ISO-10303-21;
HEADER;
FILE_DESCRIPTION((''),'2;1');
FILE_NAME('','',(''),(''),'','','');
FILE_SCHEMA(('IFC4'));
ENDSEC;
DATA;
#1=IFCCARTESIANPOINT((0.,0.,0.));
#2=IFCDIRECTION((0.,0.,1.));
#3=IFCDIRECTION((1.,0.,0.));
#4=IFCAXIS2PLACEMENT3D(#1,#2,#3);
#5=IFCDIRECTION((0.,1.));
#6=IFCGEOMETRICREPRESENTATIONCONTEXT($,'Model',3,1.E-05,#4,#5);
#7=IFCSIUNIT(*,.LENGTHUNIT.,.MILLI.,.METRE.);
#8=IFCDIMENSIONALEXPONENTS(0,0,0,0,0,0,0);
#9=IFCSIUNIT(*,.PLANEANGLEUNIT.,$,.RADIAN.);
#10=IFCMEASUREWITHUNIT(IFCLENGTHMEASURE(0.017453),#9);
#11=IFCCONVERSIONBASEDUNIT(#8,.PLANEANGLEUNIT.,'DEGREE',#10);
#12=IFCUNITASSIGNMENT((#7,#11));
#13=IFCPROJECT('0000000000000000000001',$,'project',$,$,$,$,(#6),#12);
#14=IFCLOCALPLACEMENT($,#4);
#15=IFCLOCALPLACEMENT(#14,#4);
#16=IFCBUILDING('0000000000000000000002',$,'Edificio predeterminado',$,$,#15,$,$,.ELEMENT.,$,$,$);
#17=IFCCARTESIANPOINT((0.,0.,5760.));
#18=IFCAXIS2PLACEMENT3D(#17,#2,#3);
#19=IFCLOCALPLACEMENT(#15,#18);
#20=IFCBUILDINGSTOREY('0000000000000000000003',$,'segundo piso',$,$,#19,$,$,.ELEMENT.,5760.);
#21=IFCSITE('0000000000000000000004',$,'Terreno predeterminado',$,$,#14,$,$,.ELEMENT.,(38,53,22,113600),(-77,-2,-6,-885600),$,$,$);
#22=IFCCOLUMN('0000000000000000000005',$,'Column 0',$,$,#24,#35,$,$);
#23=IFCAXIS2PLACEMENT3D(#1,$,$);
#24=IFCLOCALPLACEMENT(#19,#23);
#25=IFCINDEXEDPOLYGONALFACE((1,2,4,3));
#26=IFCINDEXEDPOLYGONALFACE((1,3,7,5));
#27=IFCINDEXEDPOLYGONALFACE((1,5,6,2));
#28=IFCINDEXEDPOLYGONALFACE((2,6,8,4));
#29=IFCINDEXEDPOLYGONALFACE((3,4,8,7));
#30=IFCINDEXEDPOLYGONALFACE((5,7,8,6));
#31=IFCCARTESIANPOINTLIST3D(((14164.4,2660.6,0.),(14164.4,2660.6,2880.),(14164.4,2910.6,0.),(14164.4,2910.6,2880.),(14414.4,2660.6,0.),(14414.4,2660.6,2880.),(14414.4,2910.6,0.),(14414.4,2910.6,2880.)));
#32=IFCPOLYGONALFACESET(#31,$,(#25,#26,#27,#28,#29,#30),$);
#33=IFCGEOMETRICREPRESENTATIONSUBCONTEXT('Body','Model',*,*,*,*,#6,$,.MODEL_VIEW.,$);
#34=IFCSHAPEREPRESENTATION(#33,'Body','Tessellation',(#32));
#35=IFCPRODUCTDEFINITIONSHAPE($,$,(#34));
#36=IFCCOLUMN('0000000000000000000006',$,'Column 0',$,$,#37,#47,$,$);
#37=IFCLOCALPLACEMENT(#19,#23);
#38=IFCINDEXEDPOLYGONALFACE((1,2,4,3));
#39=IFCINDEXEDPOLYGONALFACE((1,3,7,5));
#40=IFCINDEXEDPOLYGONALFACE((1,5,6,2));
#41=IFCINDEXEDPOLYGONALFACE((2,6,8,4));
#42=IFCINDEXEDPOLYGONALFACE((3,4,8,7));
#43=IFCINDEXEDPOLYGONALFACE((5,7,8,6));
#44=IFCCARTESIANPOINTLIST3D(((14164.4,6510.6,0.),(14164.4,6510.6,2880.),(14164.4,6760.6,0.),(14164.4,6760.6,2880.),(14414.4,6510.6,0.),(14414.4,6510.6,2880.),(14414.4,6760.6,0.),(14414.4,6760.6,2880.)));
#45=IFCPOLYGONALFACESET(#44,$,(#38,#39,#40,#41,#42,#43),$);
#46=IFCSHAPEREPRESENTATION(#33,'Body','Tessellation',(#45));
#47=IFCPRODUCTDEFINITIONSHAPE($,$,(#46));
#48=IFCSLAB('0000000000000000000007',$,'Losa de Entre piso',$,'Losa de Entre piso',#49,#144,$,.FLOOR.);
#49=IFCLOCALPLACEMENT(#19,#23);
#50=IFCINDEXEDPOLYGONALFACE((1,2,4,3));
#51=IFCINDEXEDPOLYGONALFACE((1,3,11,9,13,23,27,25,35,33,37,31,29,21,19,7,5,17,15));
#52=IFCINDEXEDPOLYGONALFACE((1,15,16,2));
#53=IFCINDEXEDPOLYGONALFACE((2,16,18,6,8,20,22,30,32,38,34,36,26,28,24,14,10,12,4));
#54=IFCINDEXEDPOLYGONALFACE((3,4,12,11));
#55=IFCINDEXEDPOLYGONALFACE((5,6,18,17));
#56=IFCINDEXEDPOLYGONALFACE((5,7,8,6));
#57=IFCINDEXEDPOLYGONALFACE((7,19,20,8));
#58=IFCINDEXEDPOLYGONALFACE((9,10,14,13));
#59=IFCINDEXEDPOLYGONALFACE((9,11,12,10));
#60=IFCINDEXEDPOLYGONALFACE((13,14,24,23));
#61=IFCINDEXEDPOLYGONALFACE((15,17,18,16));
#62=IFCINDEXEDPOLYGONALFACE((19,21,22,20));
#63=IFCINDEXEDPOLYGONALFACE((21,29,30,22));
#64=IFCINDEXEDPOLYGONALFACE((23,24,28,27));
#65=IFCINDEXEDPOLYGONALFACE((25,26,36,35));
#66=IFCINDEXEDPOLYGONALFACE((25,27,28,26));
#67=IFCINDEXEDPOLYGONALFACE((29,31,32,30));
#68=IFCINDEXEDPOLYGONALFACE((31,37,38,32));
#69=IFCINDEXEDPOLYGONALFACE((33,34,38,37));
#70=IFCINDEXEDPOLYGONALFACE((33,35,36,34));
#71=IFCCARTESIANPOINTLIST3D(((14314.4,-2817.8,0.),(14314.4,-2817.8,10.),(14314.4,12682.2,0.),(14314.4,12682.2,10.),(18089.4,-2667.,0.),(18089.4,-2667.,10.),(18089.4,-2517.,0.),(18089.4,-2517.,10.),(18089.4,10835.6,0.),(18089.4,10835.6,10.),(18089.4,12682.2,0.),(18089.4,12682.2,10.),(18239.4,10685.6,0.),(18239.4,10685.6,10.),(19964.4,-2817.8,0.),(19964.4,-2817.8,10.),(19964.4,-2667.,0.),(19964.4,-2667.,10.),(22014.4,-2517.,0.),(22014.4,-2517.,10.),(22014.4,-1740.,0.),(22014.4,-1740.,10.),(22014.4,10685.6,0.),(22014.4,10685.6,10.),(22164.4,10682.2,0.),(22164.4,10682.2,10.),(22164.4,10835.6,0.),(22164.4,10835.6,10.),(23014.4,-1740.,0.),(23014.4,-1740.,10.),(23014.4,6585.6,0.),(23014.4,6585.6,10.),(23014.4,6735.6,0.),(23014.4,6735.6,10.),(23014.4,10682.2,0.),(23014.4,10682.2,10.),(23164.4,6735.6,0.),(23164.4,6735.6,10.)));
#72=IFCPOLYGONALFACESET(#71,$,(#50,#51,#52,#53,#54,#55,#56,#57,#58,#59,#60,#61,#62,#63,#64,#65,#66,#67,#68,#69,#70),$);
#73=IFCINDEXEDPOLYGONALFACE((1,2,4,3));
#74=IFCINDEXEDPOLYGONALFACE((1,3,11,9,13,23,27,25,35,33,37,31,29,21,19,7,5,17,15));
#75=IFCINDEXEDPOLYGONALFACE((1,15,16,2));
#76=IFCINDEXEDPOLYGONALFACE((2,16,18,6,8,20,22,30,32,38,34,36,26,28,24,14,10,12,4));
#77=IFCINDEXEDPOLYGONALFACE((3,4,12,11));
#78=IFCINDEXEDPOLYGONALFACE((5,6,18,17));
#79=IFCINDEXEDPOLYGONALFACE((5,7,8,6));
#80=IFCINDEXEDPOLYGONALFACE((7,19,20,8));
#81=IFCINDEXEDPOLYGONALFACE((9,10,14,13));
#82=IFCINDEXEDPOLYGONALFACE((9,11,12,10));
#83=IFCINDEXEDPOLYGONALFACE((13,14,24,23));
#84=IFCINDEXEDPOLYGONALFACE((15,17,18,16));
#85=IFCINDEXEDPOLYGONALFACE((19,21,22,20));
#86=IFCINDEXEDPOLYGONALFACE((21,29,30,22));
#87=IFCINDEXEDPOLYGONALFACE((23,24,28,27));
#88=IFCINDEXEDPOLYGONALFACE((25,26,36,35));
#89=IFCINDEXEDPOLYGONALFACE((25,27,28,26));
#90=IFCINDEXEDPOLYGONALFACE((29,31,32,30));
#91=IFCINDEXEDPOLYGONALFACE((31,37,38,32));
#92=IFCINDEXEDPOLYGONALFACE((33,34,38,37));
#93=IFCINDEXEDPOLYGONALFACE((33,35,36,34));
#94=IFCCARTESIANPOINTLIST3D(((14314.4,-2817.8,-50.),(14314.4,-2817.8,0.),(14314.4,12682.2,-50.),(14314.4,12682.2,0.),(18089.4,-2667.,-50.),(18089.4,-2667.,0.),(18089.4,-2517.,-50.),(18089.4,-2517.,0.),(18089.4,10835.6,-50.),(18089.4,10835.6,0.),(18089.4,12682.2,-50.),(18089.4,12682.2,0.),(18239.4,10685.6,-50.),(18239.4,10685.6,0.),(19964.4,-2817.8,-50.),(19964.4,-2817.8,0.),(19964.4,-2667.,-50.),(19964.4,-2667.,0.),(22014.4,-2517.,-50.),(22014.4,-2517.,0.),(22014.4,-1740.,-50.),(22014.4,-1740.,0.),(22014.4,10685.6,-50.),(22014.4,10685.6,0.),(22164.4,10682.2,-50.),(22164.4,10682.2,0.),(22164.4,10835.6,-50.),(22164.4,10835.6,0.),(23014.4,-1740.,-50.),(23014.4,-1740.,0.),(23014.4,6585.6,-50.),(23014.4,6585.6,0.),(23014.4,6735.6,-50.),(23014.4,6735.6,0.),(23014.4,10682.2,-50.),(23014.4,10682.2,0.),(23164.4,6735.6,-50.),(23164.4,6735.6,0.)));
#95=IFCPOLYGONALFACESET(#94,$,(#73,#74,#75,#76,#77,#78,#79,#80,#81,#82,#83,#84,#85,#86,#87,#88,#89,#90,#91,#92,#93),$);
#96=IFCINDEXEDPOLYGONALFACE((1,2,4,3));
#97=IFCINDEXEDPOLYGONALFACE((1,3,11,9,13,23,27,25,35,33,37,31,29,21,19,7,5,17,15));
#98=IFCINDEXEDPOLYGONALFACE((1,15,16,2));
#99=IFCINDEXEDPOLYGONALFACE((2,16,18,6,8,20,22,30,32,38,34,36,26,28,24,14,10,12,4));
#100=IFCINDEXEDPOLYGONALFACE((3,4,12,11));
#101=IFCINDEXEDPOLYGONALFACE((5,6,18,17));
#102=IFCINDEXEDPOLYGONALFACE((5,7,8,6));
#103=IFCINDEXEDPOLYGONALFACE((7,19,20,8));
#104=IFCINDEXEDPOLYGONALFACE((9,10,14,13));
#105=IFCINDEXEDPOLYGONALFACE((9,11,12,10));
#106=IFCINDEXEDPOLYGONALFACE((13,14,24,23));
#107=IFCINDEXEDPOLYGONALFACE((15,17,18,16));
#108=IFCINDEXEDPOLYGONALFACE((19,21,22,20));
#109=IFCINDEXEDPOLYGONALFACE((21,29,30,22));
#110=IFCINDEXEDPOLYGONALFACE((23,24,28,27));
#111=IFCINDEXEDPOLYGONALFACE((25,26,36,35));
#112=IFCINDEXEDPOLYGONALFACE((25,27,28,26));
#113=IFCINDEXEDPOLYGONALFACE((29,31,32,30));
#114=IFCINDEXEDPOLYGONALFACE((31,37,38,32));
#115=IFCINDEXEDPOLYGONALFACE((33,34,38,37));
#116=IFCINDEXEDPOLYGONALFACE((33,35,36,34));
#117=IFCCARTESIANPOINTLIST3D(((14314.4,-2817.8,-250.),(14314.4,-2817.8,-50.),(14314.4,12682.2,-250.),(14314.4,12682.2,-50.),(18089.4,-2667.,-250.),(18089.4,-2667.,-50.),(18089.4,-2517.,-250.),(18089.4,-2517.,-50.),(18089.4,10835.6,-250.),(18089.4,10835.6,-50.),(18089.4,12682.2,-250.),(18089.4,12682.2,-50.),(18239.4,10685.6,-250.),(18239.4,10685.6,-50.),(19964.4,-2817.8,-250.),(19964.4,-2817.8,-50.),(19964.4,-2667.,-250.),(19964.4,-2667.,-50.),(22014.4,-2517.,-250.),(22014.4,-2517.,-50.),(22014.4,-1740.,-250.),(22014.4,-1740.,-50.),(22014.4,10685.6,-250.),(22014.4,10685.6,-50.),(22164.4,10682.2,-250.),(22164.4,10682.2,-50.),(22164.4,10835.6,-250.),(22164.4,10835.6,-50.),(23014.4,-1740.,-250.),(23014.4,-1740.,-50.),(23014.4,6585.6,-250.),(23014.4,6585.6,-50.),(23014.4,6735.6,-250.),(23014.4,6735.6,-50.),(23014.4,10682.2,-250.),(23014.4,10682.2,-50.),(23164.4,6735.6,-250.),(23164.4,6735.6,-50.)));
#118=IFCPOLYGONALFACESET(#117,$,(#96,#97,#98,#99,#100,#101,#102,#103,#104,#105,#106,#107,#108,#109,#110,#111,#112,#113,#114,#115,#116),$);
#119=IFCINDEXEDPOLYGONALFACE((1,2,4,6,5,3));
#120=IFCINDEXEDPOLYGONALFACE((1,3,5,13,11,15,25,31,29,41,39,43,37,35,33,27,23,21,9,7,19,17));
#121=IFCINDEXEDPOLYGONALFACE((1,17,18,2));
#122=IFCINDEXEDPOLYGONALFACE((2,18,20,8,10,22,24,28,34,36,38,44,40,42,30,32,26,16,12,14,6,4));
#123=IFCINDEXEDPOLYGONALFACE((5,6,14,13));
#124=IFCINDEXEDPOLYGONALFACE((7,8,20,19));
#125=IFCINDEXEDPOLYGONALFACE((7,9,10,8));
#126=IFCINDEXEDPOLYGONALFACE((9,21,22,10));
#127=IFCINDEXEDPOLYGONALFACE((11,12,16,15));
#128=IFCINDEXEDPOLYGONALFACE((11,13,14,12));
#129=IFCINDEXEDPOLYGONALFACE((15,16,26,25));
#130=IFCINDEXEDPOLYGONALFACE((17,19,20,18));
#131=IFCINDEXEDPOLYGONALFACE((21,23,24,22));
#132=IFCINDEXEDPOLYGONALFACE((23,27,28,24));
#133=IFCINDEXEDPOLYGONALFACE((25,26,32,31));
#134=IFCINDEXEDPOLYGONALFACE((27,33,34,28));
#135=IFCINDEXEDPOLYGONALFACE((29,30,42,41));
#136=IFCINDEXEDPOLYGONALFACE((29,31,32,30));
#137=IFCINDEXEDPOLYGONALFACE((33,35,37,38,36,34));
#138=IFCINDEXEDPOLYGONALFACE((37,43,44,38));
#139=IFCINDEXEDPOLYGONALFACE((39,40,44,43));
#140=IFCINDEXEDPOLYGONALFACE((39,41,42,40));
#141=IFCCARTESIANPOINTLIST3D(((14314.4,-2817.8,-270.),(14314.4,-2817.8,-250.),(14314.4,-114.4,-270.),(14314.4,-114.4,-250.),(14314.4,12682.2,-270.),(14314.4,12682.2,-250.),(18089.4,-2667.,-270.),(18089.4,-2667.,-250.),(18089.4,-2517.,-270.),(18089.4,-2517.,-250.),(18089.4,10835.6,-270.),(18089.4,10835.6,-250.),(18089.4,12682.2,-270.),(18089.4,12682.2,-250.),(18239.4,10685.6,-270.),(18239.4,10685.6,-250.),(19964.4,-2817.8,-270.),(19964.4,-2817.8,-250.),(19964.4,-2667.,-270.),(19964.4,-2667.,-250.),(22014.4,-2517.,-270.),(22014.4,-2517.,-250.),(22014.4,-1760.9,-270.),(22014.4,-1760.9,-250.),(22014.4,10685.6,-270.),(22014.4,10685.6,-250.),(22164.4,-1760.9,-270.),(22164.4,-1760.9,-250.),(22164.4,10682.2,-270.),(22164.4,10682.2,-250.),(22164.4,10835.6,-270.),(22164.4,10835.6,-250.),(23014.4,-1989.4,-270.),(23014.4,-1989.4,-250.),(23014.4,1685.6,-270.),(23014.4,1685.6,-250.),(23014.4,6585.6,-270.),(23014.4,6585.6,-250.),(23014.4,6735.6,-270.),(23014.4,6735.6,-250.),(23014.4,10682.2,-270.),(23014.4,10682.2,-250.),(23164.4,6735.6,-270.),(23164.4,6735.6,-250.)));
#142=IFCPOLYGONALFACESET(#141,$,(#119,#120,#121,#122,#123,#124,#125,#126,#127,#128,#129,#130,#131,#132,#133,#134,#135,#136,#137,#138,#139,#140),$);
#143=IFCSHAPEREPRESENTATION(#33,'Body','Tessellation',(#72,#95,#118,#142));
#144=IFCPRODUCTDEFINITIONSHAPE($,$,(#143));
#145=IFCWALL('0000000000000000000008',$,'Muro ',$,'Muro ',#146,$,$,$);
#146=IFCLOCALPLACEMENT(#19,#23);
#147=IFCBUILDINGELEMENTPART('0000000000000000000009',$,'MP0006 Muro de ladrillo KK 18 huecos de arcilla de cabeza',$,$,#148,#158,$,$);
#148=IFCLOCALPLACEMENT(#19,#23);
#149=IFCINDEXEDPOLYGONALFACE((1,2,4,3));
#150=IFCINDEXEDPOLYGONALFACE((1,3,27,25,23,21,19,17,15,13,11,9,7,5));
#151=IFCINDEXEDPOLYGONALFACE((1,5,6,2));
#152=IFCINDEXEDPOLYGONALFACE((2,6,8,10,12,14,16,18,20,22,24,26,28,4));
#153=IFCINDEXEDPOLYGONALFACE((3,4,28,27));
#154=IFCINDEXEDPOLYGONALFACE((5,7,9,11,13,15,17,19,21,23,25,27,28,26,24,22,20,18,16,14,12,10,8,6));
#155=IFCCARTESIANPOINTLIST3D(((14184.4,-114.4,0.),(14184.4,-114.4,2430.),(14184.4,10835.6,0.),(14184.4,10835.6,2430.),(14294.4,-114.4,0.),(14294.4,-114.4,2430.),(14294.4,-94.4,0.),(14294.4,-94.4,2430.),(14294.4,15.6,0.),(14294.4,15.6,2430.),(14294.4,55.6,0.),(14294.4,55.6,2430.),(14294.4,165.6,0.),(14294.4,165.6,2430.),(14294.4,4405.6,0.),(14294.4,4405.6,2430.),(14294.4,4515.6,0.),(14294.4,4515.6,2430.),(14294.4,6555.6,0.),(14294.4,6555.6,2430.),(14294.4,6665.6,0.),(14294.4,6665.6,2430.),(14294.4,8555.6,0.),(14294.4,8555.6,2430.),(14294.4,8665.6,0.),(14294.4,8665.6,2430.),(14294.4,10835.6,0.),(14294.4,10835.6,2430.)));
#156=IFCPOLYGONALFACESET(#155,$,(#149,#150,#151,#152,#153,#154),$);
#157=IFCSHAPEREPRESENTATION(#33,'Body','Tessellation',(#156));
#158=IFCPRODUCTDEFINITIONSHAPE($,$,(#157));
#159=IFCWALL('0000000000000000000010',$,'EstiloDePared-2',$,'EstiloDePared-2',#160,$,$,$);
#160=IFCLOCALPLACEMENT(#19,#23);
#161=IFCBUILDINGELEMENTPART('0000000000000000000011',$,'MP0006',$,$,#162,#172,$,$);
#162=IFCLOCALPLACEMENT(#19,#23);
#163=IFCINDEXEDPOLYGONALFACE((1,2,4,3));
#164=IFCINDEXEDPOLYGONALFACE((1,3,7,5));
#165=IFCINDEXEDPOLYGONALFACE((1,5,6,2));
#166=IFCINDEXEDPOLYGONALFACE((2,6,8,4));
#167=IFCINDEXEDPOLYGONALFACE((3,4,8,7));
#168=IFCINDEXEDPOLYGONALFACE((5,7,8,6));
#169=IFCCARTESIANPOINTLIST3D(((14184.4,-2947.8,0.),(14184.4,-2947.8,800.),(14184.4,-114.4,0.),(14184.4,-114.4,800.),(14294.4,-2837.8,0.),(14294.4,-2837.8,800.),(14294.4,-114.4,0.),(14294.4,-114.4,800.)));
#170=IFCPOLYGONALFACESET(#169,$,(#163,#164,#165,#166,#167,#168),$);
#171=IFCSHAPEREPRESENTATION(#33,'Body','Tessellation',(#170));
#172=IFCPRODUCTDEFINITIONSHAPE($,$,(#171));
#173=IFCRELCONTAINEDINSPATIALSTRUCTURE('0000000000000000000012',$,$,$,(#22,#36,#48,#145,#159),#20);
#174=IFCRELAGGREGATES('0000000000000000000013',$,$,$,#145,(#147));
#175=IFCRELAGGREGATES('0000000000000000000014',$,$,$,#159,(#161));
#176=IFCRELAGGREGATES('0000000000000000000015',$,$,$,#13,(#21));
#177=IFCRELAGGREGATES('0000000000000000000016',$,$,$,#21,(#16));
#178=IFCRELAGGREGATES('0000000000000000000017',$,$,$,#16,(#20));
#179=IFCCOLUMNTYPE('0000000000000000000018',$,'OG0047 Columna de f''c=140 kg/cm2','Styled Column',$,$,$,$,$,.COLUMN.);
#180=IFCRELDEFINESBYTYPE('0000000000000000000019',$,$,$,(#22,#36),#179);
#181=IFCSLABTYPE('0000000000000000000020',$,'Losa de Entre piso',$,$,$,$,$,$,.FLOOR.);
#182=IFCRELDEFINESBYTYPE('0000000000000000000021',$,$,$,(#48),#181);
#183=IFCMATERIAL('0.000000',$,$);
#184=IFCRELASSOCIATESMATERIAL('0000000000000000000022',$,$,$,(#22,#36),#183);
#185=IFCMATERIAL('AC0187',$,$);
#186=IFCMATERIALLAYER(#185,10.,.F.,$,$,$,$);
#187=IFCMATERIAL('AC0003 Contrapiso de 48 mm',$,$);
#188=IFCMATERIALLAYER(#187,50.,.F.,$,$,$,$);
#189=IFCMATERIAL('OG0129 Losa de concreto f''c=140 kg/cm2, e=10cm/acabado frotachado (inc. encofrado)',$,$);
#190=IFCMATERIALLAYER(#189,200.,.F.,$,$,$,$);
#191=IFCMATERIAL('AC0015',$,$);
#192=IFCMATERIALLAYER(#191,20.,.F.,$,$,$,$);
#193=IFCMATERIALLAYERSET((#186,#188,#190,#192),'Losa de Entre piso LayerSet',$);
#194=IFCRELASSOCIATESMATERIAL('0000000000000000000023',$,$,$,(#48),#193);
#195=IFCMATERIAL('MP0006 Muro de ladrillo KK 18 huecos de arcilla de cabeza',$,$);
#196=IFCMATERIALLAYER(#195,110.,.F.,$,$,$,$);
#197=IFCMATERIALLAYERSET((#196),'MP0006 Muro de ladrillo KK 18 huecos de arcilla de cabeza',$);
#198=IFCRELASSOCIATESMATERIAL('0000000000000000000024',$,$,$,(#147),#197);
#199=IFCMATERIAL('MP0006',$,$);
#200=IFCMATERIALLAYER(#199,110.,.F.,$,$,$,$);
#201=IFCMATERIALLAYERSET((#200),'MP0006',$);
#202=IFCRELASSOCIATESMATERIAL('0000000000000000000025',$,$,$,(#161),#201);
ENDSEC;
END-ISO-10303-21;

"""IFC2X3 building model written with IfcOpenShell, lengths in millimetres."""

from ifc_helpers import new_model, entity, si_unit, converted_unit, direction, frame, origin_with_axes, place, context, subcontext, project, spatial, polyline, outline, extrude, material, layer, layer_set, layer_usage, type_object, element, aggregate, save


model = new_model("IFC2X3")

# Units and contexts
model_context = context("Model", 3, precision=1e-05, world=origin_with_axes(), true_north=direction((0.0, 1.0)))
body_context = subcontext(model_context, "Body", "Model", "MODEL_VIEW")
ifc_project = project(units=[si_unit("LENGTHUNIT", "METRE", prefix="MILLI"), converted_unit("PLANEANGLEUNIT", "DEGREE", entity("IfcLengthMeasure", 0.017453), si_unit("PLANEANGLEUNIT", "RADIAN"), dimensions=[0, 0, 0, 0, 0, 0, 0])], contexts=[model_context])

# Site, building, storey
site_placement = place(None, origin_with_axes())
site = spatial("IfcSite", under=ifc_project, at=site_placement, Name="Terreno predeterminado", CompositionType="ELEMENT", RefLatitude=(38, 53, 22, 113600), RefLongitude=(-77, -2, -6, -885600))
building_placement = place(site_placement, origin_with_axes())
building = spatial("IfcBuilding", under=site, at=building_placement, Name="Edificio predeterminado", CompositionType="ELEMENT")
storey_placement = place(building_placement, frame((0.0, 0.0, 5760.0), z_axis=(0.0, 0.0, 1.0), x_axis=(1.0, 0.0, 0.0)))
storey = spatial("IfcBuildingStorey", under=building, at=storey_placement, Name="segundo piso", CompositionType="ELEMENT", Elevation=5760.0)

# Columns
ifc_material_1 = material(Name="0.000000")
column_type = type_object("IfcColumnType", Name="OG0047 Columna de f'c=140 kg/cm2", Description="Styled Column", PredefinedType="COLUMN")
for number, where, z_axis, x_axis, name in (
    (1, (14289.4, 2785.6, 0.0), (0.0, 0.0, 1.0), (1.0, 0.0, 0.0), "Column 0"),
    (2, (14289.4, 6635.6, 0.0), (0.0, 0.0, 1.0), (1.0, 0.0, 0.0), "Column 0"),
):
    element("IfcColumn", number, at=place(storey_placement, frame(where, z_axis=z_axis, x_axis=x_axis)), inside=storey, type_object=column_type, material=ifc_material_1, Name=name, context=body_context, shape_type="SweptSolid", body=[
        extrude(outline(polyline([(-125.0, -125.0), (125.0, -125.0), (125.0, 125.0), (-125.0, 125.0), (-125.0, -125.0)])), origin_with_axes(), (0.0, 0.0, 1.0), 2880.0),
    ])

# Slab
ifc_material_2 = material(Name="AC0187")
ifc_layer_1 = layer(ifc_material_2, 10.0, ventilated=False)
ifc_material_3 = material(Name="AC0003 Contrapiso de 48 mm")
ifc_layer_2 = layer(ifc_material_3, 50.0, ventilated=False)
ifc_material_4 = material(Name="OG0129 Losa de concreto f'c=140 kg/cm2, e=10cm/acabado frotachado (inc. encofrado)")
ifc_layer_3 = layer(ifc_material_4, 200.0, ventilated=False)
ifc_material_5 = material(Name="AC0015")
ifc_layer_4 = layer(ifc_material_5, 20.0, ventilated=False)
ifc_layer_set_1 = layer_set([ifc_layer_1, ifc_layer_2, ifc_layer_3, ifc_layer_4], Name="Losa de Entre piso LayerSet")
ifc_layer_usage_1 = layer_usage(ifc_layer_set_1, "AXIS3", "POSITIVE", 0.0)
slab_type = type_object("IfcSlabType", Name="Losa de Entre piso", PredefinedType="FLOOR")
slab_placement = place(storey_placement, frame((0.0, 0.0, -5760.0), z_axis=(0.0, 0.0, 1.0), x_axis=(1.0, 0.0, 0.0)))
element("IfcSlab", 3, at=slab_placement, inside=storey, type_object=slab_type, material=ifc_layer_usage_1, Name="Losa de Entre piso", ObjectType="Losa de Entre piso", PredefinedType="FLOOR", context=body_context, shape_type="SweptSolid", body=[
    extrude(outline(polyline([(0.0, -777.0), (-1000.0, -777.0), (-1000.0, -9102.6), (-1150.0, -9252.6), (-1000.0, -9252.6), (-1000.0, -13199.1), (-150.0, -13199.1), (-150.0, -13352.6), (0.0, -13202.6), (3775.0, -13202.6), (3925.0, -13352.6), (3925.0, -15199.1), (7700.0, -15199.1), (7700.0, 300.9), (2050.0, 300.9), (2050.0, 150.0), (3925.0, 150.0), (3925.0, 0.0), (0.0, 0.0), (0.0, -777.0)])), frame((22014.4, -2517.0, 5760.0), z_axis=(0.0, 0.0, 1.0), x_axis=(-1.0, 0.0, 0.0)), (0.0, 0.0, 1.0), 10.0),
    extrude(outline(polyline([(0.0, -777.0), (-1000.0, -777.0), (-1000.0, -9102.6), (-1150.0, -9252.6), (-1000.0, -9252.6), (-1000.0, -13199.1), (-150.0, -13199.1), (-150.0, -13352.6), (0.0, -13202.6), (3775.0, -13202.6), (3925.0, -13352.6), (3925.0, -15199.1), (7700.0, -15199.1), (7700.0, 300.9), (2050.0, 300.9), (2050.0, 150.0), (3925.0, 150.0), (3925.0, 0.0), (0.0, 0.0), (0.0, -777.0)])), frame((22014.4, -2517.0, 5710.0), z_axis=(0.0, 0.0, 1.0), x_axis=(-1.0, 0.0, 0.0)), (0.0, 0.0, 1.0), 50.0),
    extrude(outline(polyline([(0.0, -777.0), (-1000.0, -777.0), (-1000.0, -9102.6), (-1150.0, -9252.6), (-1000.0, -9252.6), (-1000.0, -13199.1), (-150.0, -13199.1), (-150.0, -13352.6), (0.0, -13202.6), (3775.0, -13202.6), (3925.0, -13352.6), (3925.0, -15199.1), (7700.0, -15199.1), (7700.0, 300.9), (2050.0, 300.9), (2050.0, 150.0), (3925.0, 150.0), (3925.0, 0.0), (0.0, 0.0), (0.0, -777.0)])), frame((22014.4, -2517.0, 5510.0), z_axis=(0.0, 0.0, 1.0), x_axis=(-1.0, 0.0, 0.0)), (0.0, 0.0, 1.0), 200.0),
    extrude(outline(polyline([(-1305.7, 1305.7), (-3975.1, -1363.6), (5073.5, -10412.1), (6985.1, -12323.8), (10980.3, -8328.6), (10873.6, -8221.9), (9547.8, -9547.8), (9441.7, -9441.7), (12217.1, -6666.3), (11682.5, -6131.7), (11788.6, -6025.7), (12551.1, -5586.1), (9952.5, -2987.5), (6487.7, 477.3), (6487.7, 689.4), (6381.6, 583.4), (3591.0, 3374.0), (2990.0, 2773.0), (2881.5, 2881.5), (2881.5, 2669.3), (212.1, 0.0), (0.0, 0.0), (-1305.7, 1305.7)])), frame((18089.4, 10835.6, 5490.0), z_axis=(0.0, 0.0, 1.0), x_axis=(0.707107, -0.707107, 0.0)), (0.0, 0.0, 1.0), 20.0),
])

# Walls, building element parts
wall_1_placement = place(storey_placement, frame((14239.4, 10835.6, 0.0), z_axis=(0.0, 0.0, 1.0), x_axis=(0.0, -1.0, 0.0)))
wall_1 = element("IfcWall", 4, at=wall_1_placement, inside=storey, Name="Muro ", ObjectType="Muro ")
ifc_material_6 = material(Name="MP0006 Muro de ladrillo KK 18 huecos de arcilla de cabeza")
ifc_layer_5 = layer(ifc_material_6, 110.0, ventilated=False)
ifc_layer_set_2 = layer_set([ifc_layer_5], Name="MP0006 Muro de ladrillo KK 18 huecos de arcilla de cabeza")
ifc_layer_usage_2 = layer_usage(ifc_layer_set_2, "AXIS2", "NEGATIVE", -55.0)
building_element_part_1_placement = place(wall_1_placement, origin_with_axes())
building_element_part_1 = element("IfcBuildingElementPart", 5, at=building_element_part_1_placement, material=ifc_layer_usage_2, Name="MP0006 Muro de ladrillo KK 18 huecos de arcilla de cabeza", context=body_context, shape_type="SweptSolid", body=[
    extrude(outline(polyline([(4280.0, 55.0), (6320.0, 55.0), (6430.0, 55.0), (10670.0, 55.0), (10780.0, 55.0), (10820.0, 55.0), (10930.0, 55.0), (10950.0, 55.0), (10950.0, -55.0), (0.0, -55.0), (0.0, 55.0), (2170.0, 55.0), (2280.0, 55.0), (4170.0, 55.0), (4280.0, 55.0)])), origin_with_axes(), (0.0, 0.0, 1.0), 2430.0),
])
aggregate(wall_1, [building_element_part_1])
wall_2_placement = place(storey_placement, frame((14239.4, -2892.8, 0.0), z_axis=(0.0, 0.0, 1.0), x_axis=(0.0, 1.0, 0.0)))
wall_2 = element("IfcWall", 6, at=wall_2_placement, inside=storey, Name="EstiloDePared-2", ObjectType="EstiloDePared-2")
ifc_material_7 = material(Name="MP0006")
ifc_layer_6 = layer(ifc_material_7, 110.0, ventilated=False)
ifc_layer_set_3 = layer_set([ifc_layer_6], Name="MP0006")
ifc_layer_usage_3 = layer_usage(ifc_layer_set_3, "AXIS2", "NEGATIVE", -55.0)
building_element_part_2_placement = place(wall_2_placement, origin_with_axes())
building_element_part_2 = element("IfcBuildingElementPart", 7, at=building_element_part_2_placement, material=ifc_layer_usage_3, Name="MP0006", context=body_context, shape_type="SweptSolid", body=[
    extrude(outline(polyline([(2778.4, 55.0), (2778.4, -55.0), (55.0, -55.0), (-55.0, 55.0), (2778.4, 55.0)])), origin_with_axes(), (0.0, 0.0, 1.0), 800.0),
])
aggregate(wall_2, [building_element_part_2])

save(model, "model.ifc")
